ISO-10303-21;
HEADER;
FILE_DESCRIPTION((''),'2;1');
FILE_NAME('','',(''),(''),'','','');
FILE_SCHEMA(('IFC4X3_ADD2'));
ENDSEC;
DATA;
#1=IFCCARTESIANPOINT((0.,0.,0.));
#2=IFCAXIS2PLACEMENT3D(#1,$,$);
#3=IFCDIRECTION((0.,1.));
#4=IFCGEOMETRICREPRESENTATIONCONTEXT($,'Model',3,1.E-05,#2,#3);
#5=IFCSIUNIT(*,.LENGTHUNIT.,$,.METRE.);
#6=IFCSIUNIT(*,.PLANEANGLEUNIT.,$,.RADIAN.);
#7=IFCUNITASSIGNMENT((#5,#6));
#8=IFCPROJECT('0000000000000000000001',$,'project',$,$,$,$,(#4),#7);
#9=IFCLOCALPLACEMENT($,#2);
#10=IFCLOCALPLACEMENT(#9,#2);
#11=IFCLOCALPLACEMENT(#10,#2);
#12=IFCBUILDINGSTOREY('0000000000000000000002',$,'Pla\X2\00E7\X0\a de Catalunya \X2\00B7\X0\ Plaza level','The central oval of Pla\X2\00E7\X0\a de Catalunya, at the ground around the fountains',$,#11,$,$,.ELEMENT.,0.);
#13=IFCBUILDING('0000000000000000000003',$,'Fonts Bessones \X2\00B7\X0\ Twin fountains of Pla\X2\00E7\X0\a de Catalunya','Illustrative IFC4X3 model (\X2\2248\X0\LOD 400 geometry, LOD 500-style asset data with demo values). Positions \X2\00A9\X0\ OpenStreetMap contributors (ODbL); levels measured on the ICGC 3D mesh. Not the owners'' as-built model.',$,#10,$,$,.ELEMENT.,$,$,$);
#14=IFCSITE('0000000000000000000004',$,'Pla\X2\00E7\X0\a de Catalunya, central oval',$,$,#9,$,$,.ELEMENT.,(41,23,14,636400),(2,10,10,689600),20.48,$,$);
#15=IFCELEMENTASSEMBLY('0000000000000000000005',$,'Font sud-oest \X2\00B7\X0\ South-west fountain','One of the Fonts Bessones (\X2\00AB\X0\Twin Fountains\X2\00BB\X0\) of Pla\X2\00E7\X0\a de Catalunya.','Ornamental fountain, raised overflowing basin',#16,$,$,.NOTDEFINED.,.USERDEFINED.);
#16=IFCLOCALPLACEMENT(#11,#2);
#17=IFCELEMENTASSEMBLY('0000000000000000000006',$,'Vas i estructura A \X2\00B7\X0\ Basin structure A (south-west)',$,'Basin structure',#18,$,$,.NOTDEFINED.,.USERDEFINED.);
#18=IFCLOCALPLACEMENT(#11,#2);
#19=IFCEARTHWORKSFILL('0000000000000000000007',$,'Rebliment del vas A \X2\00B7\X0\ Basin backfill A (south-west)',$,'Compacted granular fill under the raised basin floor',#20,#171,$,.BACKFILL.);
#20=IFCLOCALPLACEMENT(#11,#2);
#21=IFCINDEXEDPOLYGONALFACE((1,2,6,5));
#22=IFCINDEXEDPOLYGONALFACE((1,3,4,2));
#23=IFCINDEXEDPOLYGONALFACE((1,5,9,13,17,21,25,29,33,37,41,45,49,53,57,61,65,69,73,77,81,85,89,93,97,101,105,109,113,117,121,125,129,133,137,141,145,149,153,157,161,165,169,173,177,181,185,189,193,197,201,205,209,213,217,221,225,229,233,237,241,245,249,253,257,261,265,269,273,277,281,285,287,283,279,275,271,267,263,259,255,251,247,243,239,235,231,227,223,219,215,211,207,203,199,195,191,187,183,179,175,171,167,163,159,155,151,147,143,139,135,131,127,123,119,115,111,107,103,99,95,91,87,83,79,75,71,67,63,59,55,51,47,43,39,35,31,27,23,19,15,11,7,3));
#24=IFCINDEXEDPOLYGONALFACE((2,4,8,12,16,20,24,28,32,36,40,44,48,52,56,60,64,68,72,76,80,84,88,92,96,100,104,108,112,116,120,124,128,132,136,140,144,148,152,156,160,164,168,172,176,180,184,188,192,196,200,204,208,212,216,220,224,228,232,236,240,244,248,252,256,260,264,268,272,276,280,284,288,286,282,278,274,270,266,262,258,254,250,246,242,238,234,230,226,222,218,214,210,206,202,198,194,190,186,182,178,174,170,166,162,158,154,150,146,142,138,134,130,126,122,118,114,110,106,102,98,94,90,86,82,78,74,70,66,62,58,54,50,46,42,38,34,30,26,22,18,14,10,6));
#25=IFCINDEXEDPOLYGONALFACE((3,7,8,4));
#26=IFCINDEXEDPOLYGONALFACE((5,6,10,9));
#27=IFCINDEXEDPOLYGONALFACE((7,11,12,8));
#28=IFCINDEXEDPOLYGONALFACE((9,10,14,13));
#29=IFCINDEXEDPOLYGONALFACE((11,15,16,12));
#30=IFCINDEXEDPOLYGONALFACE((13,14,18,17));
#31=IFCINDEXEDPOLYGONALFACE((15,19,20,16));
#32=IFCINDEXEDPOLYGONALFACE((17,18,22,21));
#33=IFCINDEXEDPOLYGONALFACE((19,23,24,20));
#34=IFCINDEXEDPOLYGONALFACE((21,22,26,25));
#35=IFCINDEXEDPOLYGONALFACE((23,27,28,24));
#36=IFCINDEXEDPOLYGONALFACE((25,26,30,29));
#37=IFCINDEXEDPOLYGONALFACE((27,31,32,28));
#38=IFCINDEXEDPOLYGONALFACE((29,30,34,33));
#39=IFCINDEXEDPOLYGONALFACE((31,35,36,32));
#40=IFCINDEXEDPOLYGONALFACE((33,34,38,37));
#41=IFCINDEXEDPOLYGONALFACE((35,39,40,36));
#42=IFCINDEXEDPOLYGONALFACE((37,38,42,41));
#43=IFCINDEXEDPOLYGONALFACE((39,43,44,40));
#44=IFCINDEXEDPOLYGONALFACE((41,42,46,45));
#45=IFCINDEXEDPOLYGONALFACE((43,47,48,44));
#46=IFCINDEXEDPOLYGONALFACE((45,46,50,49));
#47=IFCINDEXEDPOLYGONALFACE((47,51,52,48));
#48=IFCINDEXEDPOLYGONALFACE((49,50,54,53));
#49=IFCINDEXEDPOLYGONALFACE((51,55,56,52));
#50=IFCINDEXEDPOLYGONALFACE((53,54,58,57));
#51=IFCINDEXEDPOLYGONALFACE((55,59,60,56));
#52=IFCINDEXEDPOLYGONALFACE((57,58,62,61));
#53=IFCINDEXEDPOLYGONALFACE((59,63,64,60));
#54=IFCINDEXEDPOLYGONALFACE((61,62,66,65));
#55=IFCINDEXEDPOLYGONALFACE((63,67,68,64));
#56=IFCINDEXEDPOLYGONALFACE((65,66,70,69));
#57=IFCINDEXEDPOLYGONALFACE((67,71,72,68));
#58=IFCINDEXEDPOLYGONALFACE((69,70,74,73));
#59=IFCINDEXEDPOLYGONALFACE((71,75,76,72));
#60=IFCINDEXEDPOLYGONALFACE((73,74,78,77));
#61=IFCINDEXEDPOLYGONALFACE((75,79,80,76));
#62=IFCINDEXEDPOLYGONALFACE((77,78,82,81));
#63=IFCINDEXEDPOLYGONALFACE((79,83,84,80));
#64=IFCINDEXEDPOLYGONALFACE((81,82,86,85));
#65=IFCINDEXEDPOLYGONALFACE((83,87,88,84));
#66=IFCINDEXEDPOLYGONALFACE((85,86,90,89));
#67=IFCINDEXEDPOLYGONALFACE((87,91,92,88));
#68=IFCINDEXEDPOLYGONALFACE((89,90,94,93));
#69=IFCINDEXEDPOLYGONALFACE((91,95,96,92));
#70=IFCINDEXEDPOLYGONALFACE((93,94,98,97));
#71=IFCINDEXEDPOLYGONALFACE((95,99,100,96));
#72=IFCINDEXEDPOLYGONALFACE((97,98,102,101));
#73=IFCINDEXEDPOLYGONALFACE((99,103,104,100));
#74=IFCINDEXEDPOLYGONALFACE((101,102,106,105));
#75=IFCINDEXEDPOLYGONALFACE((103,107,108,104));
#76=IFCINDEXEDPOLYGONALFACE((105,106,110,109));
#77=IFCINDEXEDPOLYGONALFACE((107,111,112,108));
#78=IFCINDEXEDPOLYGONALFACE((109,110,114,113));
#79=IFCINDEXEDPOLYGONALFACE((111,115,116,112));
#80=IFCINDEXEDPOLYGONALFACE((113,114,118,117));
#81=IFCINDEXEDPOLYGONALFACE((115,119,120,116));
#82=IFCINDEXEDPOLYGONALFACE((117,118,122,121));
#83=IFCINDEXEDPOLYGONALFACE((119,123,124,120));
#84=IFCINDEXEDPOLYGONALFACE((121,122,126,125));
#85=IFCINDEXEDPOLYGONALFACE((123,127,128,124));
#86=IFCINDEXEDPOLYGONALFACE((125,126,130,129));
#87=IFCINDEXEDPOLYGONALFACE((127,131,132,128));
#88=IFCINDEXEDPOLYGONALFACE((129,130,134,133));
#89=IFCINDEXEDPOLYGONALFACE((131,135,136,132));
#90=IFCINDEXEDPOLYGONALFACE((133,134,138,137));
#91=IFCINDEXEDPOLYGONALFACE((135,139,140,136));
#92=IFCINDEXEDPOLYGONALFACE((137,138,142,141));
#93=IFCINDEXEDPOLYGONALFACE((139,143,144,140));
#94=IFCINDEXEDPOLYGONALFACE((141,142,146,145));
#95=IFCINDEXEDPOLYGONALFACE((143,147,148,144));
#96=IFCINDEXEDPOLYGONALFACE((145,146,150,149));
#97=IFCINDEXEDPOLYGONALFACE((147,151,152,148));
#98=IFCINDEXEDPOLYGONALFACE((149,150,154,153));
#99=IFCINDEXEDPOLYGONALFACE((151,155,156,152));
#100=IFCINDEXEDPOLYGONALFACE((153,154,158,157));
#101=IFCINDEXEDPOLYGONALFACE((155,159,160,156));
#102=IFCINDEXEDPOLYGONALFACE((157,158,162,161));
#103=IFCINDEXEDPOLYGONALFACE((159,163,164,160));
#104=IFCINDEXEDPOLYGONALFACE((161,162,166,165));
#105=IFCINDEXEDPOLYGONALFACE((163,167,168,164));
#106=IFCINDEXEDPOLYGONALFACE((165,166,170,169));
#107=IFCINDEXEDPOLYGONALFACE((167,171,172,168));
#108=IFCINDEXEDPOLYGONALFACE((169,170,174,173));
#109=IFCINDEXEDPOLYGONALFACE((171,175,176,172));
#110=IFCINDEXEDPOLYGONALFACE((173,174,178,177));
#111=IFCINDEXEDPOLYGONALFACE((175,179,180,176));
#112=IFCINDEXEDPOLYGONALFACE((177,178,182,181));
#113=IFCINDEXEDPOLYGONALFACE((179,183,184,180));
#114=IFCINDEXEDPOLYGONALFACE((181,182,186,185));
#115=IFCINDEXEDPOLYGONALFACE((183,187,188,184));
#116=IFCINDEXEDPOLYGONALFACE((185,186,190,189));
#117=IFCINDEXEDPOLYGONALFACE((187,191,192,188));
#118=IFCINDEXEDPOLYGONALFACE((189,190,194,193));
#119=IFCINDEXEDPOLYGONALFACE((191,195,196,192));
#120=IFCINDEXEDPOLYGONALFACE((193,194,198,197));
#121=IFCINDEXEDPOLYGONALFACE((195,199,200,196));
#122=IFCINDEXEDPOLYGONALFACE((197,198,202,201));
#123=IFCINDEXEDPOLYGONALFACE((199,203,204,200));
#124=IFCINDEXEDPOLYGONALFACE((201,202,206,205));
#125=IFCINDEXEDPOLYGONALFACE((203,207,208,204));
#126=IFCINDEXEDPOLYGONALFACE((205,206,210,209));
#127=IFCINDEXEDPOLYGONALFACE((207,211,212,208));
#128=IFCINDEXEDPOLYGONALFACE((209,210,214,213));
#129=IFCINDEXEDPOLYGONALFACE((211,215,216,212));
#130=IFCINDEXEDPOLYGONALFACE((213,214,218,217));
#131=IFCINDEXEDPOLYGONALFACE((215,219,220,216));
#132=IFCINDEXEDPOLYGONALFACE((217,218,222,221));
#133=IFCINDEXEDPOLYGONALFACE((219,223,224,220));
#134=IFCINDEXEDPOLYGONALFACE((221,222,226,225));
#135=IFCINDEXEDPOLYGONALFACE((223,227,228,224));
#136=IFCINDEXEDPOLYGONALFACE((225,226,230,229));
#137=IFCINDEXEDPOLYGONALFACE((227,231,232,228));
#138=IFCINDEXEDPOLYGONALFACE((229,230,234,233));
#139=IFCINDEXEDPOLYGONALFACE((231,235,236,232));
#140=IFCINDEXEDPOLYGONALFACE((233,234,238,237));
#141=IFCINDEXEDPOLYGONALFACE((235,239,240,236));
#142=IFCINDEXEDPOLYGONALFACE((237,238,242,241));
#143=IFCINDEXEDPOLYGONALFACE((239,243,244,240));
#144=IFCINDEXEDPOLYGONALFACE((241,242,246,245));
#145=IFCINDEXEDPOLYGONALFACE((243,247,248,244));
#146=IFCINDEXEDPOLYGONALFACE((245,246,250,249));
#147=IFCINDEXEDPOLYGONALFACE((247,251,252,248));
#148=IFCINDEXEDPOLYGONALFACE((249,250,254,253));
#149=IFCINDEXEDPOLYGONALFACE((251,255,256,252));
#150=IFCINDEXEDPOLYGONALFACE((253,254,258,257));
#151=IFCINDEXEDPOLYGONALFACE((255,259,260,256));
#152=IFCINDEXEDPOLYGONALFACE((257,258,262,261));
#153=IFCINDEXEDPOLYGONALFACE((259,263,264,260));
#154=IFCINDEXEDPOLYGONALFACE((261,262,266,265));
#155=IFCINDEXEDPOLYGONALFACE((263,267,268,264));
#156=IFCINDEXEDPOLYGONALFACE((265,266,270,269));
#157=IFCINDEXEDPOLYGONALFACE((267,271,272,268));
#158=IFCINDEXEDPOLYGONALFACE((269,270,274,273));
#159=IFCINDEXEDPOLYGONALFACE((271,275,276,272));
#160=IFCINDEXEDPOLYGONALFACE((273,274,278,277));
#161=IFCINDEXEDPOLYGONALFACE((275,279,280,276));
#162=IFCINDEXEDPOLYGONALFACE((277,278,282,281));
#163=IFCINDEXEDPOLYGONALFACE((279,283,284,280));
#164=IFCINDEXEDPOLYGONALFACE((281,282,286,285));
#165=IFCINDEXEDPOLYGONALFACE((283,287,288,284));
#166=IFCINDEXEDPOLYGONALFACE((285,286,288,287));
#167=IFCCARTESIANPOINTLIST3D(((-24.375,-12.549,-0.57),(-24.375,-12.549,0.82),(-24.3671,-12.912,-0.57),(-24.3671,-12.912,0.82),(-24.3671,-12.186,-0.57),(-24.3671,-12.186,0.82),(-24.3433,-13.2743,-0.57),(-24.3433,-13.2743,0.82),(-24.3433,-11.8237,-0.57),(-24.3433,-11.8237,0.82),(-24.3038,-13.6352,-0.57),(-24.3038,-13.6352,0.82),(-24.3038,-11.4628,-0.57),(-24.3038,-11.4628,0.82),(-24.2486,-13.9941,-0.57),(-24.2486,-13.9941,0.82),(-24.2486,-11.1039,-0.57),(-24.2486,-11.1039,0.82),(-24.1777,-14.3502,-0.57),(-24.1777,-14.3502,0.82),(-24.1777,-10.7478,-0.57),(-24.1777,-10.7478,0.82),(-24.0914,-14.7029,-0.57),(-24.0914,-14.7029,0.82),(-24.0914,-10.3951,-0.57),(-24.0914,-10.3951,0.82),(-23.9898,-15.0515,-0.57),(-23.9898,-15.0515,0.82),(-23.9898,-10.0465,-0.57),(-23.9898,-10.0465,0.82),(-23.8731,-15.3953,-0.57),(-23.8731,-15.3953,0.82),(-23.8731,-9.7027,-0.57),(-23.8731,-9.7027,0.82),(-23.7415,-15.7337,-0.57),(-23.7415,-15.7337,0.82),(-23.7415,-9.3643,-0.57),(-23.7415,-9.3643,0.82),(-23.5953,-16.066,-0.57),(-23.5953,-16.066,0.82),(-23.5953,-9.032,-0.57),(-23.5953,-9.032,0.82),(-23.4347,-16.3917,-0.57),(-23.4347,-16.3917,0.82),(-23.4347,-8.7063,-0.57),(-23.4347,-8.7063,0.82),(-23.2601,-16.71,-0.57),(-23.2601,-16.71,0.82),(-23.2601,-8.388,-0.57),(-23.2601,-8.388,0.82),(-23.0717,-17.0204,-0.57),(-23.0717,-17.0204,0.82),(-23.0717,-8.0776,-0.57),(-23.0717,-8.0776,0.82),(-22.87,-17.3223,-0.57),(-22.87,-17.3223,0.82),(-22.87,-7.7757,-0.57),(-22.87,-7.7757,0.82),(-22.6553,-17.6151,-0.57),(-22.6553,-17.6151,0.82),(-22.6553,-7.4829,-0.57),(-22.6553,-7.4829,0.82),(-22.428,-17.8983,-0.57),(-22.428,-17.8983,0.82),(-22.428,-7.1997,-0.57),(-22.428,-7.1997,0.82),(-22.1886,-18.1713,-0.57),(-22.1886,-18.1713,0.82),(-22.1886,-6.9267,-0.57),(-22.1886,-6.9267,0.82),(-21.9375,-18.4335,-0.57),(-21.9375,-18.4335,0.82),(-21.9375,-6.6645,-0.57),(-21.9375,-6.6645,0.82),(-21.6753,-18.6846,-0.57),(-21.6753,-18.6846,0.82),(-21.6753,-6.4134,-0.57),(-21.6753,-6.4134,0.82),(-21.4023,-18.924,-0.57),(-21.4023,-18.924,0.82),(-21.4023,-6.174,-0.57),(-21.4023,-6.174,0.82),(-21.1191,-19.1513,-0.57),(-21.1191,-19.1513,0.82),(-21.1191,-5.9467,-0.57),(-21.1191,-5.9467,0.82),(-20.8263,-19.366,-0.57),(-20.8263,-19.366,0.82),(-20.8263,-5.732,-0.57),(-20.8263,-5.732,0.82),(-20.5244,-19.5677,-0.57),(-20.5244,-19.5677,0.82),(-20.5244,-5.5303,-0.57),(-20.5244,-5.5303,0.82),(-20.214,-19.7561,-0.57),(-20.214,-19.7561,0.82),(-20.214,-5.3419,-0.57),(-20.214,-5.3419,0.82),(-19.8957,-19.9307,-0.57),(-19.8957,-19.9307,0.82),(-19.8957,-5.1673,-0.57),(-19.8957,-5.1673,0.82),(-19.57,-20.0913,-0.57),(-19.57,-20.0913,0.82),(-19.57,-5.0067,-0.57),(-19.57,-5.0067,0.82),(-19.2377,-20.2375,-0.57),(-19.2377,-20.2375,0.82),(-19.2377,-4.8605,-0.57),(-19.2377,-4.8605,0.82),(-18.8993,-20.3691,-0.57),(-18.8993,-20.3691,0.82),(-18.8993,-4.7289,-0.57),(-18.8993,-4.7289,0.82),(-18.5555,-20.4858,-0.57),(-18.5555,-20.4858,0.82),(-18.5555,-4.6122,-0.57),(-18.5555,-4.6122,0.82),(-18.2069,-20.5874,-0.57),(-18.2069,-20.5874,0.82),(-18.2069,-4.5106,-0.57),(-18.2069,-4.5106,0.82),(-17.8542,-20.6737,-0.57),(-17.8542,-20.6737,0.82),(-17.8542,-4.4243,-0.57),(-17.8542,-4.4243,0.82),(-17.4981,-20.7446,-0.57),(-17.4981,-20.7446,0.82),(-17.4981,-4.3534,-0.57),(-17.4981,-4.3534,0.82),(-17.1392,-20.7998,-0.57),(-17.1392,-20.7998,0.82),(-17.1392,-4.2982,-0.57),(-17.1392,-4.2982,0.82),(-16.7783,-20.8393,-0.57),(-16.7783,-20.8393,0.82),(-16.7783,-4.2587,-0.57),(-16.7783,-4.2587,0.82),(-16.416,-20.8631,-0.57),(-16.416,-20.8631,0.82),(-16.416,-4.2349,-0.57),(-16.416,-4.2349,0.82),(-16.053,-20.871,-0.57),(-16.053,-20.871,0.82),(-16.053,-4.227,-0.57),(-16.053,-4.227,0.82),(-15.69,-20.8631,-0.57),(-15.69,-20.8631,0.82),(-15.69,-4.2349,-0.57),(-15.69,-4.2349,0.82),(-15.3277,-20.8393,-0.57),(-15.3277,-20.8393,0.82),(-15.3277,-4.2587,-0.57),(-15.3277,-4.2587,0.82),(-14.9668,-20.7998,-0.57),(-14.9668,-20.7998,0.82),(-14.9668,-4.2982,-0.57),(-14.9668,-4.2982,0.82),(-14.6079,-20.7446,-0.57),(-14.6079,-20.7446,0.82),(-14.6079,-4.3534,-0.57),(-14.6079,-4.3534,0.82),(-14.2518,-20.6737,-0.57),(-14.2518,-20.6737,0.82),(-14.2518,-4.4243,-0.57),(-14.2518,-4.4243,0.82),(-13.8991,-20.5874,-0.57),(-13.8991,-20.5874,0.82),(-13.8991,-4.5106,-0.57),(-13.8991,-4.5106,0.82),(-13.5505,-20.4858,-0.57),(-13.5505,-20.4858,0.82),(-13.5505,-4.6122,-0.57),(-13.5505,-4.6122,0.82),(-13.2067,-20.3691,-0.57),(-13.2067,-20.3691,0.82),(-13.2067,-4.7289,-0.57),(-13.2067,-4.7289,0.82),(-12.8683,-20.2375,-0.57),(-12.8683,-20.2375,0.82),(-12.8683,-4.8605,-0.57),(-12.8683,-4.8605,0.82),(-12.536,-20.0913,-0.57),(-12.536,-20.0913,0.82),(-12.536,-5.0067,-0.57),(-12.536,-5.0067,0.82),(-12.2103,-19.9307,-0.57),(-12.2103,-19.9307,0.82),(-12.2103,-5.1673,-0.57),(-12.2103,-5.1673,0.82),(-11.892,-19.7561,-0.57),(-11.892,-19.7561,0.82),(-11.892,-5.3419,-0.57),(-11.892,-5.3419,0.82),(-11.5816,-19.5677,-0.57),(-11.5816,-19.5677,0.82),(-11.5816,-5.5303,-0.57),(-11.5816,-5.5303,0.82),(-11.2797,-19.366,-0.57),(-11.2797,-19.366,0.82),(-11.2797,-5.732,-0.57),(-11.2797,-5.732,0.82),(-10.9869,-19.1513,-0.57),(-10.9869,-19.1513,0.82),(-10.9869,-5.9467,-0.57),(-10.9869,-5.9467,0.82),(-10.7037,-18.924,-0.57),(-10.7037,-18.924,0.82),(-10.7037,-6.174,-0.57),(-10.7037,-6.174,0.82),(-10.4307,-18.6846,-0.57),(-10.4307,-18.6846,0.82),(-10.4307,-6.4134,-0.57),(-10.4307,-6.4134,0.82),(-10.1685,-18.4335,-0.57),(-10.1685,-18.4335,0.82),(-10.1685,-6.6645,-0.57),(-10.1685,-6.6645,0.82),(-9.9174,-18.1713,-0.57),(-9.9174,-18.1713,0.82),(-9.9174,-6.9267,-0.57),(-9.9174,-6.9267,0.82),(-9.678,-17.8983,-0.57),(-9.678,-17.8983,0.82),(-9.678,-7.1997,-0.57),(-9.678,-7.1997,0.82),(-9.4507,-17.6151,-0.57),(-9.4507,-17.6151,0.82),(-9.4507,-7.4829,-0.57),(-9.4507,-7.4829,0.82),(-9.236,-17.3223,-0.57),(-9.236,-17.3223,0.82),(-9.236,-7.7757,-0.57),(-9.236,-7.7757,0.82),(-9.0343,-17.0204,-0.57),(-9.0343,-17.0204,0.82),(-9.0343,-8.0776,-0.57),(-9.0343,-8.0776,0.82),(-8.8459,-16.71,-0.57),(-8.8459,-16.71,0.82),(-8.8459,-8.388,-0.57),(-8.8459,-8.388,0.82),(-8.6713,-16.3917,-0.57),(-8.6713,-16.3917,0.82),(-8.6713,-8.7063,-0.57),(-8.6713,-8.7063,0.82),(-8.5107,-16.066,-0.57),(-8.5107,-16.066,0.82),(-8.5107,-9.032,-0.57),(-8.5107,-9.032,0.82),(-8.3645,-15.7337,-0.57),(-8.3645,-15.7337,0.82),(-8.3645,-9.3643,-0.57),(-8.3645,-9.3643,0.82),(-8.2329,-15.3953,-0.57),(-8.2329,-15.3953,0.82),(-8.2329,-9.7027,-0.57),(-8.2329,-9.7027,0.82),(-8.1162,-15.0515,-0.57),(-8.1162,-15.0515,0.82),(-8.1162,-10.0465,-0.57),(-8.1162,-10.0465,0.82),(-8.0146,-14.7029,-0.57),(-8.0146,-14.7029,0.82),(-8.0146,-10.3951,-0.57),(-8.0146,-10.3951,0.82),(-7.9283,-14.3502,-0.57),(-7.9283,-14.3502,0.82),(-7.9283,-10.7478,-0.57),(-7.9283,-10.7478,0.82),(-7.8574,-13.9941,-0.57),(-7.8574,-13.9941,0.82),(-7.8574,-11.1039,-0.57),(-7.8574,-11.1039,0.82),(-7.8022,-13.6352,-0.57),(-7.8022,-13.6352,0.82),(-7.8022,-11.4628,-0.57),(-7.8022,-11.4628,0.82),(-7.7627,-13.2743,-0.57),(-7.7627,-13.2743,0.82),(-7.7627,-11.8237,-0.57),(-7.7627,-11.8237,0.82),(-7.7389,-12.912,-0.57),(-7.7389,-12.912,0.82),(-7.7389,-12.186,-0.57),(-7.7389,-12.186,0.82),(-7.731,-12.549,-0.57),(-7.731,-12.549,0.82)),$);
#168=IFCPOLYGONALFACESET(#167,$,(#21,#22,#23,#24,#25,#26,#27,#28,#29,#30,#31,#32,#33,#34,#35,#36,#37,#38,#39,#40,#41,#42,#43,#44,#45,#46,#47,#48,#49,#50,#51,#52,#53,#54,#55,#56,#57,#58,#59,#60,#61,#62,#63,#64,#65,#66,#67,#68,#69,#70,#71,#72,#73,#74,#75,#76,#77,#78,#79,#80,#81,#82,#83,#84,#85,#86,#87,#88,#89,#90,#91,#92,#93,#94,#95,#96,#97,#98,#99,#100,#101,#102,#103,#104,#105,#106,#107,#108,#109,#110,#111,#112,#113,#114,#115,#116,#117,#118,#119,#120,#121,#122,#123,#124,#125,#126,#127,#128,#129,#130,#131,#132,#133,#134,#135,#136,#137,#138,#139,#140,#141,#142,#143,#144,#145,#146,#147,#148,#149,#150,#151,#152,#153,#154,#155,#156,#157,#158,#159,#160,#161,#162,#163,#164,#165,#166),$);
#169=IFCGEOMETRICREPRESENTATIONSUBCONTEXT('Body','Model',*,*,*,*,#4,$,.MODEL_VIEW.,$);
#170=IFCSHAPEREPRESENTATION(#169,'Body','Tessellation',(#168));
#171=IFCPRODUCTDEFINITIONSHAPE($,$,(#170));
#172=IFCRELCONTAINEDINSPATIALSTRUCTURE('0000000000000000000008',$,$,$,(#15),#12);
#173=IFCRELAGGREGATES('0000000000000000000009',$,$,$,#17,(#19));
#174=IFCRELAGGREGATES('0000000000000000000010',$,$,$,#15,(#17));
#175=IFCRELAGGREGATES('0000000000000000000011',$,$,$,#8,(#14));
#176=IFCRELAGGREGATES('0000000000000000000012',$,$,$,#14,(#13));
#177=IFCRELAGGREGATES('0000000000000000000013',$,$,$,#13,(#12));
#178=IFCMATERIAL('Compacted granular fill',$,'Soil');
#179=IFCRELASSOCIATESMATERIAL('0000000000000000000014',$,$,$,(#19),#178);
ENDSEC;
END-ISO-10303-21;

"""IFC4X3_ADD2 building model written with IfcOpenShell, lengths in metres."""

from ifc_helpers import new_model, si_unit, direction, frame, origin, origin_2d_with_axis, place, context, subcontext, project, spatial, circle, extrude, material, element, aggregate, save


model = new_model("IFC4X3_ADD2")

# Units and contexts
model_context = context("Model", 3, precision=1e-05, world=origin(), true_north=direction((0.0, 1.0)))
body_context = subcontext(model_context, "Body", "Model", "MODEL_VIEW")
ifc_project = project(units=[si_unit("LENGTHUNIT", "METRE"), si_unit("PLANEANGLEUNIT", "RADIAN")], contexts=[model_context])

# Site, building, storey
site_placement = place(None, origin())
site = spatial("IfcSite", under=ifc_project, at=site_placement, Name="Plaça de Catalunya, central oval", CompositionType="ELEMENT", RefLatitude=(41, 23, 14, 636400), RefLongitude=(2, 10, 10, 689600), RefElevation=20.48)
building_placement = place(site_placement, origin())
building = spatial("IfcBuilding", under=site, at=building_placement, Name="Fonts Bessones · Twin fountains of Plaça de Catalunya", Description="Illustrative IFC4X3 model (≈LOD 400 geometry, LOD 500-style asset data with demo values). Positions © OpenStreetMap contributors (ODbL); levels measured on the ICGC 3D mesh. Not the owners' as-built model.", CompositionType="ELEMENT")
storey_placement = place(building_placement, origin())
storey = spatial("IfcBuildingStorey", under=building, at=storey_placement, Name="Plaça de Catalunya · Plaza level", Description="The central oval of Plaça de Catalunya, at the ground around the fountains", CompositionType="ELEMENT", Elevation=0.0)

# Element assemblies, earthworks fill
assembly_1_placement = place(building_placement, origin())
assembly_1 = element("IfcElementAssembly", 1, at=assembly_1_placement, inside=storey, Name="Font sud-oest · South-west fountain", Description="One of the Fonts Bessones («Twin Fountains») of Plaça de Catalunya.", ObjectType="Ornamental fountain, raised overflowing basin", AssemblyPlace="NOTDEFINED", PredefinedType="USERDEFINED")
assembly_2_placement = place(building_placement, origin())
assembly_2 = element("IfcElementAssembly", 2, at=assembly_2_placement, Name="Vas i estructura A · Basin structure A (south-west)", ObjectType="Basin structure", AssemblyPlace="NOTDEFINED", PredefinedType="USERDEFINED")
ifc_material_1 = material(Name="Compacted granular fill", Category="Soil")
earthworks_fill_placement = place(building_placement, origin())
earthworks_fill = element("IfcEarthworksFill", 3, at=earthworks_fill_placement, material=ifc_material_1, Name="Rebliment del vas A · Basin backfill A (south-west)", ObjectType="Compacted granular fill under the raised basin floor", PredefinedType="BACKFILL", context=body_context, shape_type="SweptSolid", body=[
    extrude(circle(Radius=8.322, at=origin_2d_with_axis()), frame((-16.053, -12.549, -0.57)), (0.0, 0.0, 1.0), 1.39),
])
aggregate(assembly_2, [earthworks_fill])
aggregate(assembly_1, [assembly_2])

save(model, "model.ifc")
